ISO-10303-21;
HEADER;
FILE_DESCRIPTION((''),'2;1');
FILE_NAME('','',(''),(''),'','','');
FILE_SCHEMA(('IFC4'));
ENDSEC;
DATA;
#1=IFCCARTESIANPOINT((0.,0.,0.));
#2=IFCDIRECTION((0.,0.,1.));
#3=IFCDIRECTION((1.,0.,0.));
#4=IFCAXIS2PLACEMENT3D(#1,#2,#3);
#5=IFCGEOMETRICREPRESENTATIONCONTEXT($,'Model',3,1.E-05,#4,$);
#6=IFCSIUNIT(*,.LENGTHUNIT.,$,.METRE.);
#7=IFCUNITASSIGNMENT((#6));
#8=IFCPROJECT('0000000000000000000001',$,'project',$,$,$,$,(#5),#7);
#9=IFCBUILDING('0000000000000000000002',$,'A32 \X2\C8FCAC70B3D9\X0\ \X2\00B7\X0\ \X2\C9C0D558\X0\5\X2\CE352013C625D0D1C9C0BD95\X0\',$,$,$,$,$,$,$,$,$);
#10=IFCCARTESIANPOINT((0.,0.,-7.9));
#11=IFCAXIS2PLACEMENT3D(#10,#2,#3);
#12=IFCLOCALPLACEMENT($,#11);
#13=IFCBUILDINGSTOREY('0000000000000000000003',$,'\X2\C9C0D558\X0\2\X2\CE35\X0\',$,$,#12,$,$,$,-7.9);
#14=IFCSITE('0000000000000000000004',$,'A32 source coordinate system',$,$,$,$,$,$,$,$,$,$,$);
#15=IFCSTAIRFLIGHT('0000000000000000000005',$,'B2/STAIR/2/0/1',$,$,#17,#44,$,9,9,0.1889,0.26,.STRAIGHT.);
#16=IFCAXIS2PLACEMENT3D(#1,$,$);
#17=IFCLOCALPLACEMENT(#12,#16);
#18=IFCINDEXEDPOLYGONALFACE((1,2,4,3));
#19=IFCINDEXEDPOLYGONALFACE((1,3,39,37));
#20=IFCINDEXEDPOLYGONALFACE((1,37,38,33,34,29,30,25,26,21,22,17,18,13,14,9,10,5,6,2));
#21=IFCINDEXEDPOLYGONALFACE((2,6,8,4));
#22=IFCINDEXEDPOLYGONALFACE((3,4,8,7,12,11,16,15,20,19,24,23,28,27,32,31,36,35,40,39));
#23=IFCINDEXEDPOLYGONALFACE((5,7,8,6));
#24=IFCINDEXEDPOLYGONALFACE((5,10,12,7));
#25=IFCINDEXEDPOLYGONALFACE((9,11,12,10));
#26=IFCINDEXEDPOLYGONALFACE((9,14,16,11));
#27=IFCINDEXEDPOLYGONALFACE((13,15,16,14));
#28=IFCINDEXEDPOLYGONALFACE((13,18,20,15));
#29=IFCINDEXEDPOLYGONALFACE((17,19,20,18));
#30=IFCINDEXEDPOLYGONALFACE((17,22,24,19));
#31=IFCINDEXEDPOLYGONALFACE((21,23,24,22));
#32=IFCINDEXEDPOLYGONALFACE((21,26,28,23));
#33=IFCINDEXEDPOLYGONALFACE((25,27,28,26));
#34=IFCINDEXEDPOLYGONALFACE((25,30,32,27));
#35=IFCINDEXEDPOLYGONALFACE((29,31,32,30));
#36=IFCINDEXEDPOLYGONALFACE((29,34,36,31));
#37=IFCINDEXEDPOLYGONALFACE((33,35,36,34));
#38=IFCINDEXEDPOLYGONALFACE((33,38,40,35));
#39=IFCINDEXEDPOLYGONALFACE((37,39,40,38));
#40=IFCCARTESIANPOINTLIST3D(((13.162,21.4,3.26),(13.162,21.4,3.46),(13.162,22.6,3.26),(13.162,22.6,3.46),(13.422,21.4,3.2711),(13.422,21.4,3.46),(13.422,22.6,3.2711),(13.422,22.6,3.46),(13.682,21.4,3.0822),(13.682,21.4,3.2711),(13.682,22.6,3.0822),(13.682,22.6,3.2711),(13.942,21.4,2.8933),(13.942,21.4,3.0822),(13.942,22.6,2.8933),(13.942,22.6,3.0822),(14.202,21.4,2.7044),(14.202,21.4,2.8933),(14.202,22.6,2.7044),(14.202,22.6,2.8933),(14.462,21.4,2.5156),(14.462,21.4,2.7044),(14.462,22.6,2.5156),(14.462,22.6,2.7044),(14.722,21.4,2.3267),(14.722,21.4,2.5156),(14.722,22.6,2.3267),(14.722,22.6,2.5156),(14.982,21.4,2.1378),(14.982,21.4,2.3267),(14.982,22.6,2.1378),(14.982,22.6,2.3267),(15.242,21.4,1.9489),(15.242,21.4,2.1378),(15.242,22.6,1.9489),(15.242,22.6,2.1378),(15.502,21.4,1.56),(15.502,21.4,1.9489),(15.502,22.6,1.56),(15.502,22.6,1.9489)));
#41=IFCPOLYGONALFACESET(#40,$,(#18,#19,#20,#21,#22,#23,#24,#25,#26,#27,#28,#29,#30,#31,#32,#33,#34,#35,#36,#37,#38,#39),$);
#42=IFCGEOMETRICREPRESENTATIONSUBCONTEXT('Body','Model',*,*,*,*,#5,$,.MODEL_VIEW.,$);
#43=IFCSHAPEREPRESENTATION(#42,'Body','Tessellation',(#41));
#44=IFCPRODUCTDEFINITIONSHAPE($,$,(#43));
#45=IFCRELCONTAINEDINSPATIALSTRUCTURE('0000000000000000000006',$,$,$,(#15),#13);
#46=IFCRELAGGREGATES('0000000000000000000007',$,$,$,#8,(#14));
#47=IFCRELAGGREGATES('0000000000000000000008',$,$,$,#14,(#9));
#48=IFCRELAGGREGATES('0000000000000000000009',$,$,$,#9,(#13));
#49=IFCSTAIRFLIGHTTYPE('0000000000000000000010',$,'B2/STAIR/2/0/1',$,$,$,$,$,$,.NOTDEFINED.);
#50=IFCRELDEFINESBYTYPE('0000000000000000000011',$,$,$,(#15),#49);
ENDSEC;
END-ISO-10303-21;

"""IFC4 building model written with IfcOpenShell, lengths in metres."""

from ifc_helpers import new_model, si_unit, frame, origin, origin_with_axes, place, context, subcontext, project, spatial, polyline, outline, extrude, source, transform, mapped, type_object, type_shapes, element, save


model = new_model("IFC4")

# Units and contexts
model_context = context("Model", 3, precision=1e-05, world=origin_with_axes())
body_context = subcontext(model_context, "Body", "Model", "MODEL_VIEW")
ifc_project = project(units=[si_unit("LENGTHUNIT", "METRE")], contexts=[model_context])

# Site, building, storey
site = spatial("IfcSite", under=ifc_project, Name="A32 source coordinate system")
building = spatial("IfcBuilding", under=site, Name="A32 주거동 · 지하5층–옥탑지붕")
storey_placement = place(None, frame((0.0, 0.0, -7.9), z_axis=(0.0, 0.0, 1.0), x_axis=(1.0, 0.0, 0.0)))
storey = spatial("IfcBuildingStorey", under=building, at=storey_placement, Name="지하2층", Elevation=-7.9)

# Stair flight
stair_flight_type_1 = type_object("IfcStairFlightType", Name="B2/STAIR/2/0/1", PredefinedType="NOTDEFINED")
shared_shape_1 = source(origin(), body_context, "Body", "SweptSolid", [
    extrude(outline(polyline([(0.0, 1.56), (2.34, 3.26), (2.34, 3.46), (2.08, 3.46), (2.08, 3.2711), (1.82, 3.2711), (1.82, 3.0822), (1.56, 3.0822), (1.56, 2.8933), (1.3, 2.8933), (1.3, 2.7044), (1.04, 2.7044), (1.04, 2.5156), (0.78, 2.5156), (0.78, 2.3267), (0.52, 2.3267), (0.52, 2.1378), (0.26, 2.1378), (0.26, 1.9489), (0.0, 1.9489), (0.0, 1.56)])), frame((15.502, 21.4, 0.0), z_axis=(0.0, 1.0, 0.0), x_axis=(-1.0, 0.0, 0.0)), (0.0, 0.0, 1.0), 1.2),
])
type_shapes(stair_flight_type_1, [shared_shape_1])
stair_flight_1_placement = place(storey_placement, origin_with_axes())
element("IfcStairFlight", 1, at=stair_flight_1_placement, inside=storey, type_object=stair_flight_type_1, Name="B2/STAIR/2/0/1", NumberOfRisers=9, NumberOfTreads=9, PredefinedType="STRAIGHT", RiserHeight=0.1889, TreadLength=0.26, context=body_context, shape_type="MappedRepresentation", body=[
    mapped(shared_shape_1, transform((0.0, 0.0, 0.0), scale=1.0)),
])

save(model, "model.ifc")
